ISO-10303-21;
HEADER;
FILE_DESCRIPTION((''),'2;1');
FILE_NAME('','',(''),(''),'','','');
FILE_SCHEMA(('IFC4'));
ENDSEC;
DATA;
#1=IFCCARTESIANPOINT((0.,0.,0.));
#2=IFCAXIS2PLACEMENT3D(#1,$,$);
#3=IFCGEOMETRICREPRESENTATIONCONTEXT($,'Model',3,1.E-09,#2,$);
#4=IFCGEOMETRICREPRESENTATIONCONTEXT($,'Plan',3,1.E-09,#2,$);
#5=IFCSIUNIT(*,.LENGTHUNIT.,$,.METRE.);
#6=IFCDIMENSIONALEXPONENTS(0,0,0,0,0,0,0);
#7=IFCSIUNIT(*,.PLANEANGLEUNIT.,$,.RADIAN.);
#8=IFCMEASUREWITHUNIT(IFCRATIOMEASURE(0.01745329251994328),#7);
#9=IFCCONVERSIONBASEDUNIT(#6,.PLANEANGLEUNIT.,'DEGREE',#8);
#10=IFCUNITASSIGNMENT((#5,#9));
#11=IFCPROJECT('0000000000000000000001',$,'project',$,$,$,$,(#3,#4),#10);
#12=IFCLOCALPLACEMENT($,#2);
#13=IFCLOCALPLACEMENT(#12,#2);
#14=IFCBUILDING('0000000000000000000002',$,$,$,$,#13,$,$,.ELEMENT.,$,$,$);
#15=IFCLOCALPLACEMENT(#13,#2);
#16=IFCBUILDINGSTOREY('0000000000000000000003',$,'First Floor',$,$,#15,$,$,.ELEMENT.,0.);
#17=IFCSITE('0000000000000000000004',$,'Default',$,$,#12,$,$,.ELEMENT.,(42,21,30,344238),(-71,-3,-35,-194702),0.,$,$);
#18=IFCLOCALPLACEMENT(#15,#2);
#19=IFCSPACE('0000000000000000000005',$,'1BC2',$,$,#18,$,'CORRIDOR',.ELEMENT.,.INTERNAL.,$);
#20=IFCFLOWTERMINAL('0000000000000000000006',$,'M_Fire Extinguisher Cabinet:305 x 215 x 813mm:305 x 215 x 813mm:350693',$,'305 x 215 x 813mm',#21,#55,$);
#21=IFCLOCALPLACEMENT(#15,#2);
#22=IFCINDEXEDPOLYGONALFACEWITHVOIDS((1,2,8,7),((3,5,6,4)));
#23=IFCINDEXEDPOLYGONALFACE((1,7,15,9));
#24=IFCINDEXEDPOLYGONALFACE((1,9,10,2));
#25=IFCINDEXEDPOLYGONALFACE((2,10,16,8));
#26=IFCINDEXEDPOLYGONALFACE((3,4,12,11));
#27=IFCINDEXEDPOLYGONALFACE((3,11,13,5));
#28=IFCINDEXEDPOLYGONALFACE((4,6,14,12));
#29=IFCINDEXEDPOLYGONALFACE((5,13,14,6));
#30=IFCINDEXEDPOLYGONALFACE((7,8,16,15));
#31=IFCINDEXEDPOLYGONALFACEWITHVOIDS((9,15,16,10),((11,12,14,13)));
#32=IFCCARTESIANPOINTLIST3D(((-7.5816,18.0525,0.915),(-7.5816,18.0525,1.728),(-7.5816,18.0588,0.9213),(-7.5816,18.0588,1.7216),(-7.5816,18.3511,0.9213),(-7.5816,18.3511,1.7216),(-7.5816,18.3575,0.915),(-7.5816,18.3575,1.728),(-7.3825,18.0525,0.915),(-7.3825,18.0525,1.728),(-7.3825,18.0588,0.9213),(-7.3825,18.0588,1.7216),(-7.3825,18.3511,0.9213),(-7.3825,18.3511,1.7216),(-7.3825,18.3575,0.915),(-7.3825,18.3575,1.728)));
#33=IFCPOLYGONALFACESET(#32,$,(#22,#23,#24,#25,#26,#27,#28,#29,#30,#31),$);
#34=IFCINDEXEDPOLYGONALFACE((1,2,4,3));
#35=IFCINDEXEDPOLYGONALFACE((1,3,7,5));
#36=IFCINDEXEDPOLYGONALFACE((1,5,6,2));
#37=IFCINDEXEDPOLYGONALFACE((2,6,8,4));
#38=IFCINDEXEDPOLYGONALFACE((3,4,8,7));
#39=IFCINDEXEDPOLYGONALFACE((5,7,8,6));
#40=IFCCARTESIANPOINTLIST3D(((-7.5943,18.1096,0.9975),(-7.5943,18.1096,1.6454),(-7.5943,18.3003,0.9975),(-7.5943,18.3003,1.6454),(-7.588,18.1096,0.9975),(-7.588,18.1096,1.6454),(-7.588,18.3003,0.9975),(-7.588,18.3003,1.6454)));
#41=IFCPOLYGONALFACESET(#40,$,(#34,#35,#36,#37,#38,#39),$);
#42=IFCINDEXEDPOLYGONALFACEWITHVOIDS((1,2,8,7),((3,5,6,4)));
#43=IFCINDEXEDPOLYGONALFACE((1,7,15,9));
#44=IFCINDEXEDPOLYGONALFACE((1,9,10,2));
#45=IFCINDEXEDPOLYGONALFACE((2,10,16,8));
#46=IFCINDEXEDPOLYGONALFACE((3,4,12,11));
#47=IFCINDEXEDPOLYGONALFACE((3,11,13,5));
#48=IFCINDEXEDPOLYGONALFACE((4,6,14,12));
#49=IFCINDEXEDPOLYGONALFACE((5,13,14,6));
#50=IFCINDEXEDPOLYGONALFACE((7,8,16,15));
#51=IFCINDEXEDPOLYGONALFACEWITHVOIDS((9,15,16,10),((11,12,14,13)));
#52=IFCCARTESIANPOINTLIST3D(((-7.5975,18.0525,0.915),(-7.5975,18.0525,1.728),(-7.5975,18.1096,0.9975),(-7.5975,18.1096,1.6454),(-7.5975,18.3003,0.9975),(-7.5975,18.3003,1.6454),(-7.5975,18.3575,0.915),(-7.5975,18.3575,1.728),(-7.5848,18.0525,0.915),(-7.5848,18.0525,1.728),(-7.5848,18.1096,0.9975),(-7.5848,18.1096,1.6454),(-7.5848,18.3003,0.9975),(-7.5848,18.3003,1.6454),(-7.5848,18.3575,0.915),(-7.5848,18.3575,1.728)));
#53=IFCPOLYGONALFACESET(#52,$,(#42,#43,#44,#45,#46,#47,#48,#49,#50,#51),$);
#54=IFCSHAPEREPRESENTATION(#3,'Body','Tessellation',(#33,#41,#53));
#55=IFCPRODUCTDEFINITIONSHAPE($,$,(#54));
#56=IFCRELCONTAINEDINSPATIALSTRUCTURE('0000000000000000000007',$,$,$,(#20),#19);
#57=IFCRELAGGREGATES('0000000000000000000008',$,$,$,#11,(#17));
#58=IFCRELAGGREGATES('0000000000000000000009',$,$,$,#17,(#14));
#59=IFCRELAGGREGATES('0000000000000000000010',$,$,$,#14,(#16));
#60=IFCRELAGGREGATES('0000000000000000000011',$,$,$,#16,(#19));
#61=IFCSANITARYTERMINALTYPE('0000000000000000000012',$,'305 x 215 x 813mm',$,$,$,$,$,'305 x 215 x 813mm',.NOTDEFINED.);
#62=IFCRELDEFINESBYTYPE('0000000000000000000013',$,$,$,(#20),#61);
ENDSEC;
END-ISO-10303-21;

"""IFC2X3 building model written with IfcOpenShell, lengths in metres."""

from ifc_helpers import new_model, entity, si_unit, converted_unit, frame, origin, origin_2d_with_axis, place, context, project, spatial, polyline, rectangle, outline, extrude, source, transform, mapped, type_object, type_shapes, element, save


model = new_model("IFC2X3")

# Units and contexts
model_context = context("Model", 3, precision=1e-09, world=origin())
plan_context = context("Plan", 3, precision=1e-09, world=origin())
ifc_project = project(units=[si_unit("LENGTHUNIT", "METRE"), converted_unit("PLANEANGLEUNIT", "DEGREE", entity("IfcRatioMeasure", 0.01745329251994328), si_unit("PLANEANGLEUNIT", "RADIAN"), dimensions=[0, 0, 0, 0, 0, 0, 0])], contexts=[model_context, plan_context])

# Site, building, storey
site_placement = place(None, origin())
site = spatial("IfcSite", under=ifc_project, at=site_placement, Name="Default", CompositionType="ELEMENT", RefLatitude=(42, 21, 30, 344238), RefLongitude=(-71, -3, -35, -194702), RefElevation=0.0)
building_placement = place(site_placement, origin())
building = spatial("IfcBuilding", under=site, at=building_placement, CompositionType="ELEMENT")
storey_placement = place(building_placement, origin())
storey = spatial("IfcBuildingStorey", under=building, at=storey_placement, Name="First Floor", CompositionType="ELEMENT", Elevation=0.0)

# Shared definitions
space_1_placement = place(storey_placement, origin())
space_1 = spatial("IfcSpace", under=storey, at=space_1_placement, Name="1BC2", LongName="CORRIDOR", CompositionType="ELEMENT", InteriorOrExteriorSpace="INTERNAL")

# Flow terminal
sanitary_terminal_type_1 = type_object("IfcSanitaryTerminalType", Name="305 x 215 x 813mm", ElementType="305 x 215 x 813mm", PredefinedType="NOTDEFINED")
shared_shape_1 = source(origin(), model_context, "Body", "SweptSolid", [
    extrude(outline(polyline([(-0.1525, -0.4065), (0.1525, -0.4065), (0.1525, 0.4065), (-0.1525, 0.4065), (-0.1525, -0.4065)]), holes=[polyline([(-0.1462, -0.4001), (-0.1462, 0.4002), (0.1462, 0.4002), (0.1462, -0.4001), (-0.1462, -0.4001)])]), frame((-0.1096, 0.027, 1.3215), z_axis=(0.0, 1.0, 0.0), x_axis=(1.0, 0.0, 0.0)), (0.0, 0.0, 1.0), 0.1991),
    extrude(rectangle(XDim=0.0064, YDim=0.1907, at=origin_2d_with_axis()), frame((-0.1096, 0.2356, 0.9975), z_axis=(0.0, 0.0, 1.0), x_axis=(0.0, -1.0, 0.0)), (0.0, 0.0, 1.0), 0.6479),
    extrude(outline(polyline([(-0.1525, -0.4065), (0.1525, -0.4065), (0.1525, 0.4065), (-0.1525, 0.4065), (-0.1525, -0.4065)]), holes=[polyline([(-0.0953, -0.3239), (-0.0953, 0.324), (0.0954, 0.324), (0.0954, -0.3239), (-0.0953, -0.3239)])]), frame((-0.1096, 0.2293, 1.3215), z_axis=(0.0, 1.0, 0.0), x_axis=(1.0, 0.0, 0.0)), (0.0, 0.0, 1.0), 0.0127),
])
type_shapes(sanitary_terminal_type_1, [shared_shape_1])
flow_terminal_1_placement = place(space_1_placement, frame((-7.3555, 18.3146, 0.0), z_axis=(0.0, 0.0, 1.0), x_axis=(0.0, 1.0, 0.0)))
element("IfcFlowTerminal", 1, at=flow_terminal_1_placement, inside=space_1, type_object=sanitary_terminal_type_1, Name="M_Fire Extinguisher Cabinet:305 x 215 x 813mm:305 x 215 x 813mm:350693", ObjectType="305 x 215 x 813mm", context=model_context, shape_type="MappedRepresentation", body=[
    mapped(shared_shape_1, transform((0.0, 0.0, 0.0), scale=1.0)),
])

save(model, "model.ifc")
